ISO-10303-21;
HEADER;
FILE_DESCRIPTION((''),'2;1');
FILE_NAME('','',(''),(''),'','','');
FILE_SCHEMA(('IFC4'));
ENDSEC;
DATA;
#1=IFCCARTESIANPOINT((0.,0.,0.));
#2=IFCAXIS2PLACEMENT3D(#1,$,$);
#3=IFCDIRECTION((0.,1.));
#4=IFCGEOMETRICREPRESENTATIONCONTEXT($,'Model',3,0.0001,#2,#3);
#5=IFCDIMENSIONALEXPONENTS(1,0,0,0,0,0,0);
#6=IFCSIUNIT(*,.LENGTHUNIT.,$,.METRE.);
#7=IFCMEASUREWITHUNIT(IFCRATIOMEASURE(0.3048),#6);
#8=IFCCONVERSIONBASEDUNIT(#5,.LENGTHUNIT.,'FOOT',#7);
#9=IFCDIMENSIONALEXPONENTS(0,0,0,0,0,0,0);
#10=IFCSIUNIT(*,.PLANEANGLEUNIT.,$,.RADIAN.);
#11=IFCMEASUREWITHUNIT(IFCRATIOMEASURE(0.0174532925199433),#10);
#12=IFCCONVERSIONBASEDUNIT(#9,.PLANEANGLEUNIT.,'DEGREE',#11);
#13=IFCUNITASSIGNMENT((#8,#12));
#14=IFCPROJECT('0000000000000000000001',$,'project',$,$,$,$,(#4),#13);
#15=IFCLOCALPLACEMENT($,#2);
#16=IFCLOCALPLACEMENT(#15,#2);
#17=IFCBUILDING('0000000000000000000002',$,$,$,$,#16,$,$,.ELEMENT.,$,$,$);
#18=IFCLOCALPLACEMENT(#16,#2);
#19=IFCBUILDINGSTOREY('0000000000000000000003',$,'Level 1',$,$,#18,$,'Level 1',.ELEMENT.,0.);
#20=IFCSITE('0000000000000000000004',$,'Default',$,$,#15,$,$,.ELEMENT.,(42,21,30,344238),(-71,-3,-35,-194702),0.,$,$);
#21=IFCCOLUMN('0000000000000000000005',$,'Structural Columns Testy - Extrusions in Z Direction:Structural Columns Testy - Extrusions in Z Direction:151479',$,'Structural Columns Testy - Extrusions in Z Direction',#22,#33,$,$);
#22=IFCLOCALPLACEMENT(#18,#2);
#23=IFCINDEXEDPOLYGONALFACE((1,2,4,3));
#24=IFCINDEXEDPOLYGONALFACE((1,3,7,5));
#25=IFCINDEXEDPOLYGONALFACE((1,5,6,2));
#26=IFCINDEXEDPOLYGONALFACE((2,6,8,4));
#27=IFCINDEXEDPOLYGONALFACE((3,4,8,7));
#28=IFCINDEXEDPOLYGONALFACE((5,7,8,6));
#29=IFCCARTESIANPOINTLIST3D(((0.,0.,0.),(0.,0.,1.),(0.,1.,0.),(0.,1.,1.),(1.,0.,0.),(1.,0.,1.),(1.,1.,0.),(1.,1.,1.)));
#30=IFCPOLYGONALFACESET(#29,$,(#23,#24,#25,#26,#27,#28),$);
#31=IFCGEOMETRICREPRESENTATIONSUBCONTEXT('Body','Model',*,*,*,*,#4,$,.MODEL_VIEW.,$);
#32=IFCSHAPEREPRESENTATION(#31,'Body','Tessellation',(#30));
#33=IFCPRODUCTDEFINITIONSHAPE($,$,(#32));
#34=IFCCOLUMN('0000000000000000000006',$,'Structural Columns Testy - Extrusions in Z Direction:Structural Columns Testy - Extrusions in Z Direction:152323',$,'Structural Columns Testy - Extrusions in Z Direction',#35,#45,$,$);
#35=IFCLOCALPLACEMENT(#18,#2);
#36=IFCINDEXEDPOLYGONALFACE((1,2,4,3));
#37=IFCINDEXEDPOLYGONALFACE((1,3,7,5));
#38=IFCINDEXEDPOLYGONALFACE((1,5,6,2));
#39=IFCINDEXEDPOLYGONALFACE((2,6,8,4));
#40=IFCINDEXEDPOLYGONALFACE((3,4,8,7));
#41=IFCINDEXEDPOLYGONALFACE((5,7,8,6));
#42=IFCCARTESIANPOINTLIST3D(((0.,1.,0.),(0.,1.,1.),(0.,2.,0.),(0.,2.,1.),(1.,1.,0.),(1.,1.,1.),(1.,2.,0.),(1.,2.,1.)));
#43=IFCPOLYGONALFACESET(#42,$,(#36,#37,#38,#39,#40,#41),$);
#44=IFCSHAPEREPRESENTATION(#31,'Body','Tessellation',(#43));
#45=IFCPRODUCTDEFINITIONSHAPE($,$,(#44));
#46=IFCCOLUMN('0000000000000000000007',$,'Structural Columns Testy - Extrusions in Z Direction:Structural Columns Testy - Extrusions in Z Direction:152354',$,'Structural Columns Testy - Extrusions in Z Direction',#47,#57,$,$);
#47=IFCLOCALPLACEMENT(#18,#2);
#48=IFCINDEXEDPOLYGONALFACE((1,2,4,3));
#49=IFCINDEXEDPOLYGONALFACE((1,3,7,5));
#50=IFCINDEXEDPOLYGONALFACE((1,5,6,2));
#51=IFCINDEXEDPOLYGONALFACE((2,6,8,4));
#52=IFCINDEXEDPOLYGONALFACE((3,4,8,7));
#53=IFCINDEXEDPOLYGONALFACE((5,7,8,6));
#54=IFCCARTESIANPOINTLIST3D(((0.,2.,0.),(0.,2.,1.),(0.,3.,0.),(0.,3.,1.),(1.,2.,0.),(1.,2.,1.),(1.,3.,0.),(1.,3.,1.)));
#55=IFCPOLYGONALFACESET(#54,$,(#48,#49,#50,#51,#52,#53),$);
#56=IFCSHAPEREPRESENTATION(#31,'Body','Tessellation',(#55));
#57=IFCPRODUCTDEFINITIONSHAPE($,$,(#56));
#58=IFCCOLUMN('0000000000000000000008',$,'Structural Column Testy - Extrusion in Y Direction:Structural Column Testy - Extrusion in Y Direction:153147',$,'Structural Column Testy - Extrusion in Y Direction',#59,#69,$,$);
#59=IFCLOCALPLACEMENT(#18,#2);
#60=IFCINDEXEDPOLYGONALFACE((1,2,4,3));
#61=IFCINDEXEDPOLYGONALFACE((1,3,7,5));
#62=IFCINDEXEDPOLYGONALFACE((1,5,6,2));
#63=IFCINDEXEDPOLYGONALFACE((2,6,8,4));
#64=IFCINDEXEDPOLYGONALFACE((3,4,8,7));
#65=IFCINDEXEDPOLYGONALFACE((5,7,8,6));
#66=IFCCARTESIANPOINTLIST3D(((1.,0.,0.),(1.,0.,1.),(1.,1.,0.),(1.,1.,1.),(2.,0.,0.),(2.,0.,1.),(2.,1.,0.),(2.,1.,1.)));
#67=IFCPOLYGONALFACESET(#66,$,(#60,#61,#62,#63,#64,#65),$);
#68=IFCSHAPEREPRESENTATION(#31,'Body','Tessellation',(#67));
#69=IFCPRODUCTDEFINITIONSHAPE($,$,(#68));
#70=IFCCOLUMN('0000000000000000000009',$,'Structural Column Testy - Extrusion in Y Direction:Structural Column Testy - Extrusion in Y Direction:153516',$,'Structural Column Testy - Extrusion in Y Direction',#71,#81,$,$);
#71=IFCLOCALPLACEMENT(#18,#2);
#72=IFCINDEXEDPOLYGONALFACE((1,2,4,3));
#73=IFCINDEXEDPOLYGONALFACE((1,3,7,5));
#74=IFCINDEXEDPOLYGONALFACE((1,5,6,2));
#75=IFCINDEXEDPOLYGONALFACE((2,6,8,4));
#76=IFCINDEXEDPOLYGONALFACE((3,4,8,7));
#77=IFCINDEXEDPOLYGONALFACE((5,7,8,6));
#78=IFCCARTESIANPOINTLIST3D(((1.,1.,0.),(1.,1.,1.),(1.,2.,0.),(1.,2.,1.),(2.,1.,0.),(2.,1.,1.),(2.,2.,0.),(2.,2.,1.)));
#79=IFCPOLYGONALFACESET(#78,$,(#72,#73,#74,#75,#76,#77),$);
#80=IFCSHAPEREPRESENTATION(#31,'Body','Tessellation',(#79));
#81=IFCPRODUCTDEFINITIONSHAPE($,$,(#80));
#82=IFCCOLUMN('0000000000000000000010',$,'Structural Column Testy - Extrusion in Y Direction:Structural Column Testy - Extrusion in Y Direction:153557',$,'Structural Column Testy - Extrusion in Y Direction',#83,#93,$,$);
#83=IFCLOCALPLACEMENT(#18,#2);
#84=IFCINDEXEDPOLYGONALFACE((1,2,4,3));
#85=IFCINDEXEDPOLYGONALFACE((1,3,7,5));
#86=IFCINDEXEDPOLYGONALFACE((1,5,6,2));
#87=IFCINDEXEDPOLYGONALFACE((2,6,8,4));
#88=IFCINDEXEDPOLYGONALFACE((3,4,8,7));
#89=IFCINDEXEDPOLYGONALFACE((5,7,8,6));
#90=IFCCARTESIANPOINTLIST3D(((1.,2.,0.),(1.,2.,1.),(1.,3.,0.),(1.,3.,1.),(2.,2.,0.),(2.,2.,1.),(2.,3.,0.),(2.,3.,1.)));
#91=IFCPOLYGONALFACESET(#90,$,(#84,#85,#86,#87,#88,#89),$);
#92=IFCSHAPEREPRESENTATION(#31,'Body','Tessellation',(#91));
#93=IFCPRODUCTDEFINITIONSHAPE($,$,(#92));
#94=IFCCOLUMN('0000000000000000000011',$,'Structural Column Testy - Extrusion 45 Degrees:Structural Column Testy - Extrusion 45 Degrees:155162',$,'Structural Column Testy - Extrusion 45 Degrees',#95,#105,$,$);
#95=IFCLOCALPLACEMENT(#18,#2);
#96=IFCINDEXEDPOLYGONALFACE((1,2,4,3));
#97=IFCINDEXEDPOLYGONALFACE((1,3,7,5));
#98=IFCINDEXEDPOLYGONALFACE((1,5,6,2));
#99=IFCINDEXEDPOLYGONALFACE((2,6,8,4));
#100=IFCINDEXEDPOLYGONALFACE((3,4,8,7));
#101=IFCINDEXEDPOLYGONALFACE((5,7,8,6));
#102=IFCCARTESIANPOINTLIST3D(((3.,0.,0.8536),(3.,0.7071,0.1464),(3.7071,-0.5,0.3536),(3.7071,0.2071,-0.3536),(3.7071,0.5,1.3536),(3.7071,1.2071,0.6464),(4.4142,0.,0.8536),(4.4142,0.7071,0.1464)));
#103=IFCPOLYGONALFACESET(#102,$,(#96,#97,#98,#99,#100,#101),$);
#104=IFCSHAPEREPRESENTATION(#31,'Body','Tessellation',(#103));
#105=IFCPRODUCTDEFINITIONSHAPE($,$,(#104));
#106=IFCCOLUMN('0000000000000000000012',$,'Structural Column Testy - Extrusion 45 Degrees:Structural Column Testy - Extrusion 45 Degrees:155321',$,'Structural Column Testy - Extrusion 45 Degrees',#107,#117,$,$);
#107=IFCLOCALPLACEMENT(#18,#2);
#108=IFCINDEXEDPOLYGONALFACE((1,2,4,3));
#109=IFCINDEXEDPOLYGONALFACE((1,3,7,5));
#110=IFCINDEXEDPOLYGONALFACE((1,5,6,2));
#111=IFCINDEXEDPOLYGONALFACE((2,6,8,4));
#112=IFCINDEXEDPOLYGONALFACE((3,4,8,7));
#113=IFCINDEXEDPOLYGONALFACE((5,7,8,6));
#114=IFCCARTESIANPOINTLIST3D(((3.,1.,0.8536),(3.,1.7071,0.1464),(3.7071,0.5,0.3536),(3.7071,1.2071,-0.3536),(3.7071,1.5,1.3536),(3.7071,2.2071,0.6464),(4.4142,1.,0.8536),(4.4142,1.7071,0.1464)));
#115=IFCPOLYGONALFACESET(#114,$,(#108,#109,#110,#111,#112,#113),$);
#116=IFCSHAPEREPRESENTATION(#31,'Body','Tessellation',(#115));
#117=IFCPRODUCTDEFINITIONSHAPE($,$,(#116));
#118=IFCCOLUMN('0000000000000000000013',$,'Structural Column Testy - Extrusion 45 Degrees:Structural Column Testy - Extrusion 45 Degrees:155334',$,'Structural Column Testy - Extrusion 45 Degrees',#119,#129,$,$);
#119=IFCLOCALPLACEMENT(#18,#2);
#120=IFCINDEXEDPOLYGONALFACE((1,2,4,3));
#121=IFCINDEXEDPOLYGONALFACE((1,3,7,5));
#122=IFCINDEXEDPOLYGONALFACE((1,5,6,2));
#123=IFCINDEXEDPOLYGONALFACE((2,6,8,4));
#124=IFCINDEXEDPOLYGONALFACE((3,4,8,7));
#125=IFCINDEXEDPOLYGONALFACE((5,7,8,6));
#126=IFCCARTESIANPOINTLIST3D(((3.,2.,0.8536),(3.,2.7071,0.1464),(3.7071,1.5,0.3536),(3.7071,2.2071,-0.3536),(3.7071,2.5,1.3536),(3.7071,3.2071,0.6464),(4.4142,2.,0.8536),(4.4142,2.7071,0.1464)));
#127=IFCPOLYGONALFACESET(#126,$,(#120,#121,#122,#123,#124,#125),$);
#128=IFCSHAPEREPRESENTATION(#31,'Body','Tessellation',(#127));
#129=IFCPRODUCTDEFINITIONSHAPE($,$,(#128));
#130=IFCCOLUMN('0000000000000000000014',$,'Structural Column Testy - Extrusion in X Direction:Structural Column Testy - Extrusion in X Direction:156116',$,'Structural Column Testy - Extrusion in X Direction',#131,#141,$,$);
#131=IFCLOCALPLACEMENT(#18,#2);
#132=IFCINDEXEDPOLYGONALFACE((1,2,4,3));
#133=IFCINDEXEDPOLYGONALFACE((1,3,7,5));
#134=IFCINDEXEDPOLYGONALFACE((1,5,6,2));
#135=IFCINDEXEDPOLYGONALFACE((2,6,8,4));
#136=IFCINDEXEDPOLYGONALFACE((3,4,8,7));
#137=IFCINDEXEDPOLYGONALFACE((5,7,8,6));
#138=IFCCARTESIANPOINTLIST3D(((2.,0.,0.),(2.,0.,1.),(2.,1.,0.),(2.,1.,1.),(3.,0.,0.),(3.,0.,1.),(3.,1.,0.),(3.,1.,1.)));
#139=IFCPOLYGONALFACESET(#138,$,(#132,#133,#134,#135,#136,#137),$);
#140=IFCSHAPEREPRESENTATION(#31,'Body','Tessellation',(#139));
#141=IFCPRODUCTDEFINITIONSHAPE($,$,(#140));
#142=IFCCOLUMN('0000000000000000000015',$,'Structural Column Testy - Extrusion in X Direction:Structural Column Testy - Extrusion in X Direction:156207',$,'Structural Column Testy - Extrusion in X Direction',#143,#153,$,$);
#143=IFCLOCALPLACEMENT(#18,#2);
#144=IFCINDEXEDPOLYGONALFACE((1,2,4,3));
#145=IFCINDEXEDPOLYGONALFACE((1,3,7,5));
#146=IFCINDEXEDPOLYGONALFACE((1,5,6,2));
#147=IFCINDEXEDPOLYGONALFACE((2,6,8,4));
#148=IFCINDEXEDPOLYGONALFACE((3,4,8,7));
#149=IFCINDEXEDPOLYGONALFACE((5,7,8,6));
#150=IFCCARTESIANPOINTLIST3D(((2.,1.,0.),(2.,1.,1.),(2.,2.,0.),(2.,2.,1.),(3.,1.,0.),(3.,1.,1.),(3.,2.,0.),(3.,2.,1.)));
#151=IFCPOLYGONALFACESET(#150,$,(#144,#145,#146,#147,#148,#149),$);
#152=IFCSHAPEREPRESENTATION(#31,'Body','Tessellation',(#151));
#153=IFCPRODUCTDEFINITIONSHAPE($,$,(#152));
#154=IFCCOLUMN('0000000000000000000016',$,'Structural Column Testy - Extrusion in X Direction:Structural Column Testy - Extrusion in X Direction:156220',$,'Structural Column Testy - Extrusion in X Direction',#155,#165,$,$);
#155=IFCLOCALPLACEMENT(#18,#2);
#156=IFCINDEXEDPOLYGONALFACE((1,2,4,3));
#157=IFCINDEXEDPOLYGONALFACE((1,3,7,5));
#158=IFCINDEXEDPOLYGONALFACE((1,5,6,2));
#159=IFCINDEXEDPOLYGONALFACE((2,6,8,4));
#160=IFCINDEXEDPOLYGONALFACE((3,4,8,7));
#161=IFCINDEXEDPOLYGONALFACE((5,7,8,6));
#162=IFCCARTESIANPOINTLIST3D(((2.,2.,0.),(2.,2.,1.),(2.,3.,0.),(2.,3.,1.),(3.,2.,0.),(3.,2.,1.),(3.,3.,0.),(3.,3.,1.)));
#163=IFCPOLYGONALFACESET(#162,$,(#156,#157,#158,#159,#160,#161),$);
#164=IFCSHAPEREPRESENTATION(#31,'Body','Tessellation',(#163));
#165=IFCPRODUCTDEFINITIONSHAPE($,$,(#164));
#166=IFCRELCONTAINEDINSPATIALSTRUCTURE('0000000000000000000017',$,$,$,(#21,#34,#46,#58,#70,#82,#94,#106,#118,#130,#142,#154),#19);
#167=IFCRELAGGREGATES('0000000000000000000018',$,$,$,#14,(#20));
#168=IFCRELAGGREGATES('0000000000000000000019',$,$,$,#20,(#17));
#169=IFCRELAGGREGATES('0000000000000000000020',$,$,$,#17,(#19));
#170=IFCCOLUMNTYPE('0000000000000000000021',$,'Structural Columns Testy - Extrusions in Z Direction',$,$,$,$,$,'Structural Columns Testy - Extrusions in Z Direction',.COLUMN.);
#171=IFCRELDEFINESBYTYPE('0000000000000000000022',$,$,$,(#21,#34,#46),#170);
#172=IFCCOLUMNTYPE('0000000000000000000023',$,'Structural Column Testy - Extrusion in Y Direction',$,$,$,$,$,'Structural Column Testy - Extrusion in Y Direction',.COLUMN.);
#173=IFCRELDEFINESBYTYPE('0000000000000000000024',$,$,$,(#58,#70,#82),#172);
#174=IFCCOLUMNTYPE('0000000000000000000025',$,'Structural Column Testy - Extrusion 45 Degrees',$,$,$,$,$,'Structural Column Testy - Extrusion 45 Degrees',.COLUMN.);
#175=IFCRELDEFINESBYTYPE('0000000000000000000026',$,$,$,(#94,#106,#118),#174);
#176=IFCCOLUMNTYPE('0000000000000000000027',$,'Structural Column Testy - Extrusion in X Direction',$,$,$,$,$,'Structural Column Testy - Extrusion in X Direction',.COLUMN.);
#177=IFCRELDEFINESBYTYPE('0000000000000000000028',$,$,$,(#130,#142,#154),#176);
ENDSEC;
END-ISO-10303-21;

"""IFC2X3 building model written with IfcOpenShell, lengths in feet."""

from ifc_helpers import new_model, entity, si_unit, converted_unit, direction, frame, frame_2d, origin, place, context, subcontext, project, spatial, rectangle, extrude, source, transform, mapped, type_object, type_shapes, element, save


model = new_model("IFC2X3")

# Units and contexts
model_context = context("Model", 3, precision=0.0001, world=origin(), true_north=direction((0.0, 1.0)))
body_context = subcontext(model_context, "Body", "Model", "MODEL_VIEW")
ifc_project = project(units=[converted_unit("LENGTHUNIT", "FOOT", entity("IfcRatioMeasure", 0.3048), si_unit("LENGTHUNIT", "METRE"), dimensions=[1, 0, 0, 0, 0, 0, 0]), converted_unit("PLANEANGLEUNIT", "DEGREE", entity("IfcRatioMeasure", 0.0174532925199433), si_unit("PLANEANGLEUNIT", "RADIAN"), dimensions=[0, 0, 0, 0, 0, 0, 0])], contexts=[model_context])

# Site, building, storey
site_placement = place(None, origin())
site = spatial("IfcSite", under=ifc_project, at=site_placement, Name="Default", CompositionType="ELEMENT", RefLatitude=(42, 21, 30, 344238), RefLongitude=(-71, -3, -35, -194702), RefElevation=0.0)
building_placement = place(site_placement, origin())
building = spatial("IfcBuilding", under=site, at=building_placement, CompositionType="ELEMENT")
storey_placement = place(building_placement, origin())
storey = spatial("IfcBuildingStorey", under=building, at=storey_placement, Name="Level 1", LongName="Level 1", CompositionType="ELEMENT", Elevation=0.0)

# Columns
column_type_1 = type_object("IfcColumnType", Name="Structural Columns Testy - Extrusions in Z Direction", ElementType="Structural Columns Testy - Extrusions in Z Direction", PredefinedType="COLUMN")
shared_shape_1 = source(origin(), body_context, "Body", "SweptSolid", [
    extrude(rectangle(XDim=1.0, YDim=1.0, at=frame_2d((0.0, 0.0), x_axis=(1.0, 0.0))), frame((0.5, 0.5, 0.0), z_axis=(0.0, 0.0, 1.0), x_axis=(0.0, -1.0, 0.0)), (0.0, 0.0, 1.0), 1.0),
])
type_shapes(column_type_1, [shared_shape_1])
for number, where, name in (
    (1, (0.0, 0.0, 0.0), "Structural Columns Testy - Extrusions in Z Direction:Structural Columns Testy - Extrusions in Z Direction:151479"),
    (2, (0.0, 1.0, 0.0), "Structural Columns Testy - Extrusions in Z Direction:Structural Columns Testy - Extrusions in Z Direction:152323"),
    (3, (0.0, 2.0, 0.0), "Structural Columns Testy - Extrusions in Z Direction:Structural Columns Testy - Extrusions in Z Direction:152354"),
):
    element("IfcColumn", number, at=place(storey_placement, frame(where)), inside=storey, type_object=column_type_1, Name=name, ObjectType="Structural Columns Testy - Extrusions in Z Direction", context=body_context, shape_type="MappedRepresentation", body=[
        mapped(shared_shape_1, transform((0.0, 0.0, 0.0), scale=1.0)),
    ])
column_type_2 = type_object("IfcColumnType", Name="Structural Column Testy - Extrusion in Y Direction", ElementType="Structural Column Testy - Extrusion in Y Direction", PredefinedType="COLUMN")
shared_shape_2 = source(origin(), body_context, "Body", "SweptSolid", [
    extrude(rectangle(XDim=1.0, YDim=1.0, at=frame_2d((0.0, 0.0), x_axis=(1.0, 0.0))), frame((0.5, -0.5, 0.0), z_axis=(0.0, 0.0, 1.0), x_axis=(0.0, -1.0, 0.0)), (0.0, 0.0, 1.0), 1.0),
])
type_shapes(column_type_2, [shared_shape_2])
for number, where, name in (
    (4, (1.0, 1.0, 0.0), "Structural Column Testy - Extrusion in Y Direction:Structural Column Testy - Extrusion in Y Direction:153147"),
    (5, (1.0, 2.0, 0.0), "Structural Column Testy - Extrusion in Y Direction:Structural Column Testy - Extrusion in Y Direction:153516"),
    (6, (1.0, 3.0, 0.0), "Structural Column Testy - Extrusion in Y Direction:Structural Column Testy - Extrusion in Y Direction:153557"),
):
    element("IfcColumn", number, at=place(storey_placement, frame(where)), inside=storey, type_object=column_type_2, Name=name, ObjectType="Structural Column Testy - Extrusion in Y Direction", context=body_context, shape_type="MappedRepresentation", body=[
        mapped(shared_shape_2, transform((0.0, 0.0, 0.0), scale=1.0)),
    ])
column_type_3 = type_object("IfcColumnType", Name="Structural Column Testy - Extrusion 45 Degrees", ElementType="Structural Column Testy - Extrusion 45 Degrees", PredefinedType="COLUMN")
shared_shape_3 = source(origin(), body_context, "Body", "SweptSolid", [
    extrude(rectangle(XDim=1.0, YDim=1.0, at=frame_2d((0.0, 0.0), x_axis=(1.0, 0.0))), frame((0.5, -0.1464, 0.1464), z_axis=(0.0, -0.707107, 0.707107), x_axis=(-0.707107, 0.5, 0.5)), (0.0, 0.0, 1.0), 1.0),
])
type_shapes(column_type_3, [shared_shape_3])
for number, where, name in (
    (7, (3.2071, 0.8536, 0.0), "Structural Column Testy - Extrusion 45 Degrees:Structural Column Testy - Extrusion 45 Degrees:155162"),
    (8, (3.2071, 1.8536, 0.0), "Structural Column Testy - Extrusion 45 Degrees:Structural Column Testy - Extrusion 45 Degrees:155321"),
    (9, (3.2071, 2.8536, 0.0), "Structural Column Testy - Extrusion 45 Degrees:Structural Column Testy - Extrusion 45 Degrees:155334"),
):
    element("IfcColumn", number, at=place(storey_placement, frame(where)), inside=storey, type_object=column_type_3, Name=name, ObjectType="Structural Column Testy - Extrusion 45 Degrees", context=body_context, shape_type="MappedRepresentation", body=[
        mapped(shared_shape_3, transform((0.0, 0.0, 0.0), scale=1.0)),
    ])
column_type_4 = type_object("IfcColumnType", Name="Structural Column Testy - Extrusion in X Direction", ElementType="Structural Column Testy - Extrusion in X Direction", PredefinedType="COLUMN")
shared_shape_4 = source(origin(), body_context, "Body", "SweptSolid", [
    extrude(rectangle(XDim=1.0, YDim=1.0, at=frame_2d((0.0, 0.0), x_axis=(1.0, 0.0))), frame((0.5, -0.5, 0.0), z_axis=(0.0, 0.0, 1.0), x_axis=(0.0, -1.0, 0.0)), (0.0, 0.0, 1.0), 1.0),
])
type_shapes(column_type_4, [shared_shape_4])
for number, where, name in (
    (10, (2.0, 1.0, 0.0), "Structural Column Testy - Extrusion in X Direction:Structural Column Testy - Extrusion in X Direction:156116"),
    (11, (2.0, 2.0, 0.0), "Structural Column Testy - Extrusion in X Direction:Structural Column Testy - Extrusion in X Direction:156207"),
    (12, (2.0, 3.0, 0.0), "Structural Column Testy - Extrusion in X Direction:Structural Column Testy - Extrusion in X Direction:156220"),
):
    element("IfcColumn", number, at=place(storey_placement, frame(where)), inside=storey, type_object=column_type_4, Name=name, ObjectType="Structural Column Testy - Extrusion in X Direction", context=body_context, shape_type="MappedRepresentation", body=[
        mapped(shared_shape_4, transform((0.0, 0.0, 0.0), scale=1.0)),
    ])

save(model, "model.ifc")
